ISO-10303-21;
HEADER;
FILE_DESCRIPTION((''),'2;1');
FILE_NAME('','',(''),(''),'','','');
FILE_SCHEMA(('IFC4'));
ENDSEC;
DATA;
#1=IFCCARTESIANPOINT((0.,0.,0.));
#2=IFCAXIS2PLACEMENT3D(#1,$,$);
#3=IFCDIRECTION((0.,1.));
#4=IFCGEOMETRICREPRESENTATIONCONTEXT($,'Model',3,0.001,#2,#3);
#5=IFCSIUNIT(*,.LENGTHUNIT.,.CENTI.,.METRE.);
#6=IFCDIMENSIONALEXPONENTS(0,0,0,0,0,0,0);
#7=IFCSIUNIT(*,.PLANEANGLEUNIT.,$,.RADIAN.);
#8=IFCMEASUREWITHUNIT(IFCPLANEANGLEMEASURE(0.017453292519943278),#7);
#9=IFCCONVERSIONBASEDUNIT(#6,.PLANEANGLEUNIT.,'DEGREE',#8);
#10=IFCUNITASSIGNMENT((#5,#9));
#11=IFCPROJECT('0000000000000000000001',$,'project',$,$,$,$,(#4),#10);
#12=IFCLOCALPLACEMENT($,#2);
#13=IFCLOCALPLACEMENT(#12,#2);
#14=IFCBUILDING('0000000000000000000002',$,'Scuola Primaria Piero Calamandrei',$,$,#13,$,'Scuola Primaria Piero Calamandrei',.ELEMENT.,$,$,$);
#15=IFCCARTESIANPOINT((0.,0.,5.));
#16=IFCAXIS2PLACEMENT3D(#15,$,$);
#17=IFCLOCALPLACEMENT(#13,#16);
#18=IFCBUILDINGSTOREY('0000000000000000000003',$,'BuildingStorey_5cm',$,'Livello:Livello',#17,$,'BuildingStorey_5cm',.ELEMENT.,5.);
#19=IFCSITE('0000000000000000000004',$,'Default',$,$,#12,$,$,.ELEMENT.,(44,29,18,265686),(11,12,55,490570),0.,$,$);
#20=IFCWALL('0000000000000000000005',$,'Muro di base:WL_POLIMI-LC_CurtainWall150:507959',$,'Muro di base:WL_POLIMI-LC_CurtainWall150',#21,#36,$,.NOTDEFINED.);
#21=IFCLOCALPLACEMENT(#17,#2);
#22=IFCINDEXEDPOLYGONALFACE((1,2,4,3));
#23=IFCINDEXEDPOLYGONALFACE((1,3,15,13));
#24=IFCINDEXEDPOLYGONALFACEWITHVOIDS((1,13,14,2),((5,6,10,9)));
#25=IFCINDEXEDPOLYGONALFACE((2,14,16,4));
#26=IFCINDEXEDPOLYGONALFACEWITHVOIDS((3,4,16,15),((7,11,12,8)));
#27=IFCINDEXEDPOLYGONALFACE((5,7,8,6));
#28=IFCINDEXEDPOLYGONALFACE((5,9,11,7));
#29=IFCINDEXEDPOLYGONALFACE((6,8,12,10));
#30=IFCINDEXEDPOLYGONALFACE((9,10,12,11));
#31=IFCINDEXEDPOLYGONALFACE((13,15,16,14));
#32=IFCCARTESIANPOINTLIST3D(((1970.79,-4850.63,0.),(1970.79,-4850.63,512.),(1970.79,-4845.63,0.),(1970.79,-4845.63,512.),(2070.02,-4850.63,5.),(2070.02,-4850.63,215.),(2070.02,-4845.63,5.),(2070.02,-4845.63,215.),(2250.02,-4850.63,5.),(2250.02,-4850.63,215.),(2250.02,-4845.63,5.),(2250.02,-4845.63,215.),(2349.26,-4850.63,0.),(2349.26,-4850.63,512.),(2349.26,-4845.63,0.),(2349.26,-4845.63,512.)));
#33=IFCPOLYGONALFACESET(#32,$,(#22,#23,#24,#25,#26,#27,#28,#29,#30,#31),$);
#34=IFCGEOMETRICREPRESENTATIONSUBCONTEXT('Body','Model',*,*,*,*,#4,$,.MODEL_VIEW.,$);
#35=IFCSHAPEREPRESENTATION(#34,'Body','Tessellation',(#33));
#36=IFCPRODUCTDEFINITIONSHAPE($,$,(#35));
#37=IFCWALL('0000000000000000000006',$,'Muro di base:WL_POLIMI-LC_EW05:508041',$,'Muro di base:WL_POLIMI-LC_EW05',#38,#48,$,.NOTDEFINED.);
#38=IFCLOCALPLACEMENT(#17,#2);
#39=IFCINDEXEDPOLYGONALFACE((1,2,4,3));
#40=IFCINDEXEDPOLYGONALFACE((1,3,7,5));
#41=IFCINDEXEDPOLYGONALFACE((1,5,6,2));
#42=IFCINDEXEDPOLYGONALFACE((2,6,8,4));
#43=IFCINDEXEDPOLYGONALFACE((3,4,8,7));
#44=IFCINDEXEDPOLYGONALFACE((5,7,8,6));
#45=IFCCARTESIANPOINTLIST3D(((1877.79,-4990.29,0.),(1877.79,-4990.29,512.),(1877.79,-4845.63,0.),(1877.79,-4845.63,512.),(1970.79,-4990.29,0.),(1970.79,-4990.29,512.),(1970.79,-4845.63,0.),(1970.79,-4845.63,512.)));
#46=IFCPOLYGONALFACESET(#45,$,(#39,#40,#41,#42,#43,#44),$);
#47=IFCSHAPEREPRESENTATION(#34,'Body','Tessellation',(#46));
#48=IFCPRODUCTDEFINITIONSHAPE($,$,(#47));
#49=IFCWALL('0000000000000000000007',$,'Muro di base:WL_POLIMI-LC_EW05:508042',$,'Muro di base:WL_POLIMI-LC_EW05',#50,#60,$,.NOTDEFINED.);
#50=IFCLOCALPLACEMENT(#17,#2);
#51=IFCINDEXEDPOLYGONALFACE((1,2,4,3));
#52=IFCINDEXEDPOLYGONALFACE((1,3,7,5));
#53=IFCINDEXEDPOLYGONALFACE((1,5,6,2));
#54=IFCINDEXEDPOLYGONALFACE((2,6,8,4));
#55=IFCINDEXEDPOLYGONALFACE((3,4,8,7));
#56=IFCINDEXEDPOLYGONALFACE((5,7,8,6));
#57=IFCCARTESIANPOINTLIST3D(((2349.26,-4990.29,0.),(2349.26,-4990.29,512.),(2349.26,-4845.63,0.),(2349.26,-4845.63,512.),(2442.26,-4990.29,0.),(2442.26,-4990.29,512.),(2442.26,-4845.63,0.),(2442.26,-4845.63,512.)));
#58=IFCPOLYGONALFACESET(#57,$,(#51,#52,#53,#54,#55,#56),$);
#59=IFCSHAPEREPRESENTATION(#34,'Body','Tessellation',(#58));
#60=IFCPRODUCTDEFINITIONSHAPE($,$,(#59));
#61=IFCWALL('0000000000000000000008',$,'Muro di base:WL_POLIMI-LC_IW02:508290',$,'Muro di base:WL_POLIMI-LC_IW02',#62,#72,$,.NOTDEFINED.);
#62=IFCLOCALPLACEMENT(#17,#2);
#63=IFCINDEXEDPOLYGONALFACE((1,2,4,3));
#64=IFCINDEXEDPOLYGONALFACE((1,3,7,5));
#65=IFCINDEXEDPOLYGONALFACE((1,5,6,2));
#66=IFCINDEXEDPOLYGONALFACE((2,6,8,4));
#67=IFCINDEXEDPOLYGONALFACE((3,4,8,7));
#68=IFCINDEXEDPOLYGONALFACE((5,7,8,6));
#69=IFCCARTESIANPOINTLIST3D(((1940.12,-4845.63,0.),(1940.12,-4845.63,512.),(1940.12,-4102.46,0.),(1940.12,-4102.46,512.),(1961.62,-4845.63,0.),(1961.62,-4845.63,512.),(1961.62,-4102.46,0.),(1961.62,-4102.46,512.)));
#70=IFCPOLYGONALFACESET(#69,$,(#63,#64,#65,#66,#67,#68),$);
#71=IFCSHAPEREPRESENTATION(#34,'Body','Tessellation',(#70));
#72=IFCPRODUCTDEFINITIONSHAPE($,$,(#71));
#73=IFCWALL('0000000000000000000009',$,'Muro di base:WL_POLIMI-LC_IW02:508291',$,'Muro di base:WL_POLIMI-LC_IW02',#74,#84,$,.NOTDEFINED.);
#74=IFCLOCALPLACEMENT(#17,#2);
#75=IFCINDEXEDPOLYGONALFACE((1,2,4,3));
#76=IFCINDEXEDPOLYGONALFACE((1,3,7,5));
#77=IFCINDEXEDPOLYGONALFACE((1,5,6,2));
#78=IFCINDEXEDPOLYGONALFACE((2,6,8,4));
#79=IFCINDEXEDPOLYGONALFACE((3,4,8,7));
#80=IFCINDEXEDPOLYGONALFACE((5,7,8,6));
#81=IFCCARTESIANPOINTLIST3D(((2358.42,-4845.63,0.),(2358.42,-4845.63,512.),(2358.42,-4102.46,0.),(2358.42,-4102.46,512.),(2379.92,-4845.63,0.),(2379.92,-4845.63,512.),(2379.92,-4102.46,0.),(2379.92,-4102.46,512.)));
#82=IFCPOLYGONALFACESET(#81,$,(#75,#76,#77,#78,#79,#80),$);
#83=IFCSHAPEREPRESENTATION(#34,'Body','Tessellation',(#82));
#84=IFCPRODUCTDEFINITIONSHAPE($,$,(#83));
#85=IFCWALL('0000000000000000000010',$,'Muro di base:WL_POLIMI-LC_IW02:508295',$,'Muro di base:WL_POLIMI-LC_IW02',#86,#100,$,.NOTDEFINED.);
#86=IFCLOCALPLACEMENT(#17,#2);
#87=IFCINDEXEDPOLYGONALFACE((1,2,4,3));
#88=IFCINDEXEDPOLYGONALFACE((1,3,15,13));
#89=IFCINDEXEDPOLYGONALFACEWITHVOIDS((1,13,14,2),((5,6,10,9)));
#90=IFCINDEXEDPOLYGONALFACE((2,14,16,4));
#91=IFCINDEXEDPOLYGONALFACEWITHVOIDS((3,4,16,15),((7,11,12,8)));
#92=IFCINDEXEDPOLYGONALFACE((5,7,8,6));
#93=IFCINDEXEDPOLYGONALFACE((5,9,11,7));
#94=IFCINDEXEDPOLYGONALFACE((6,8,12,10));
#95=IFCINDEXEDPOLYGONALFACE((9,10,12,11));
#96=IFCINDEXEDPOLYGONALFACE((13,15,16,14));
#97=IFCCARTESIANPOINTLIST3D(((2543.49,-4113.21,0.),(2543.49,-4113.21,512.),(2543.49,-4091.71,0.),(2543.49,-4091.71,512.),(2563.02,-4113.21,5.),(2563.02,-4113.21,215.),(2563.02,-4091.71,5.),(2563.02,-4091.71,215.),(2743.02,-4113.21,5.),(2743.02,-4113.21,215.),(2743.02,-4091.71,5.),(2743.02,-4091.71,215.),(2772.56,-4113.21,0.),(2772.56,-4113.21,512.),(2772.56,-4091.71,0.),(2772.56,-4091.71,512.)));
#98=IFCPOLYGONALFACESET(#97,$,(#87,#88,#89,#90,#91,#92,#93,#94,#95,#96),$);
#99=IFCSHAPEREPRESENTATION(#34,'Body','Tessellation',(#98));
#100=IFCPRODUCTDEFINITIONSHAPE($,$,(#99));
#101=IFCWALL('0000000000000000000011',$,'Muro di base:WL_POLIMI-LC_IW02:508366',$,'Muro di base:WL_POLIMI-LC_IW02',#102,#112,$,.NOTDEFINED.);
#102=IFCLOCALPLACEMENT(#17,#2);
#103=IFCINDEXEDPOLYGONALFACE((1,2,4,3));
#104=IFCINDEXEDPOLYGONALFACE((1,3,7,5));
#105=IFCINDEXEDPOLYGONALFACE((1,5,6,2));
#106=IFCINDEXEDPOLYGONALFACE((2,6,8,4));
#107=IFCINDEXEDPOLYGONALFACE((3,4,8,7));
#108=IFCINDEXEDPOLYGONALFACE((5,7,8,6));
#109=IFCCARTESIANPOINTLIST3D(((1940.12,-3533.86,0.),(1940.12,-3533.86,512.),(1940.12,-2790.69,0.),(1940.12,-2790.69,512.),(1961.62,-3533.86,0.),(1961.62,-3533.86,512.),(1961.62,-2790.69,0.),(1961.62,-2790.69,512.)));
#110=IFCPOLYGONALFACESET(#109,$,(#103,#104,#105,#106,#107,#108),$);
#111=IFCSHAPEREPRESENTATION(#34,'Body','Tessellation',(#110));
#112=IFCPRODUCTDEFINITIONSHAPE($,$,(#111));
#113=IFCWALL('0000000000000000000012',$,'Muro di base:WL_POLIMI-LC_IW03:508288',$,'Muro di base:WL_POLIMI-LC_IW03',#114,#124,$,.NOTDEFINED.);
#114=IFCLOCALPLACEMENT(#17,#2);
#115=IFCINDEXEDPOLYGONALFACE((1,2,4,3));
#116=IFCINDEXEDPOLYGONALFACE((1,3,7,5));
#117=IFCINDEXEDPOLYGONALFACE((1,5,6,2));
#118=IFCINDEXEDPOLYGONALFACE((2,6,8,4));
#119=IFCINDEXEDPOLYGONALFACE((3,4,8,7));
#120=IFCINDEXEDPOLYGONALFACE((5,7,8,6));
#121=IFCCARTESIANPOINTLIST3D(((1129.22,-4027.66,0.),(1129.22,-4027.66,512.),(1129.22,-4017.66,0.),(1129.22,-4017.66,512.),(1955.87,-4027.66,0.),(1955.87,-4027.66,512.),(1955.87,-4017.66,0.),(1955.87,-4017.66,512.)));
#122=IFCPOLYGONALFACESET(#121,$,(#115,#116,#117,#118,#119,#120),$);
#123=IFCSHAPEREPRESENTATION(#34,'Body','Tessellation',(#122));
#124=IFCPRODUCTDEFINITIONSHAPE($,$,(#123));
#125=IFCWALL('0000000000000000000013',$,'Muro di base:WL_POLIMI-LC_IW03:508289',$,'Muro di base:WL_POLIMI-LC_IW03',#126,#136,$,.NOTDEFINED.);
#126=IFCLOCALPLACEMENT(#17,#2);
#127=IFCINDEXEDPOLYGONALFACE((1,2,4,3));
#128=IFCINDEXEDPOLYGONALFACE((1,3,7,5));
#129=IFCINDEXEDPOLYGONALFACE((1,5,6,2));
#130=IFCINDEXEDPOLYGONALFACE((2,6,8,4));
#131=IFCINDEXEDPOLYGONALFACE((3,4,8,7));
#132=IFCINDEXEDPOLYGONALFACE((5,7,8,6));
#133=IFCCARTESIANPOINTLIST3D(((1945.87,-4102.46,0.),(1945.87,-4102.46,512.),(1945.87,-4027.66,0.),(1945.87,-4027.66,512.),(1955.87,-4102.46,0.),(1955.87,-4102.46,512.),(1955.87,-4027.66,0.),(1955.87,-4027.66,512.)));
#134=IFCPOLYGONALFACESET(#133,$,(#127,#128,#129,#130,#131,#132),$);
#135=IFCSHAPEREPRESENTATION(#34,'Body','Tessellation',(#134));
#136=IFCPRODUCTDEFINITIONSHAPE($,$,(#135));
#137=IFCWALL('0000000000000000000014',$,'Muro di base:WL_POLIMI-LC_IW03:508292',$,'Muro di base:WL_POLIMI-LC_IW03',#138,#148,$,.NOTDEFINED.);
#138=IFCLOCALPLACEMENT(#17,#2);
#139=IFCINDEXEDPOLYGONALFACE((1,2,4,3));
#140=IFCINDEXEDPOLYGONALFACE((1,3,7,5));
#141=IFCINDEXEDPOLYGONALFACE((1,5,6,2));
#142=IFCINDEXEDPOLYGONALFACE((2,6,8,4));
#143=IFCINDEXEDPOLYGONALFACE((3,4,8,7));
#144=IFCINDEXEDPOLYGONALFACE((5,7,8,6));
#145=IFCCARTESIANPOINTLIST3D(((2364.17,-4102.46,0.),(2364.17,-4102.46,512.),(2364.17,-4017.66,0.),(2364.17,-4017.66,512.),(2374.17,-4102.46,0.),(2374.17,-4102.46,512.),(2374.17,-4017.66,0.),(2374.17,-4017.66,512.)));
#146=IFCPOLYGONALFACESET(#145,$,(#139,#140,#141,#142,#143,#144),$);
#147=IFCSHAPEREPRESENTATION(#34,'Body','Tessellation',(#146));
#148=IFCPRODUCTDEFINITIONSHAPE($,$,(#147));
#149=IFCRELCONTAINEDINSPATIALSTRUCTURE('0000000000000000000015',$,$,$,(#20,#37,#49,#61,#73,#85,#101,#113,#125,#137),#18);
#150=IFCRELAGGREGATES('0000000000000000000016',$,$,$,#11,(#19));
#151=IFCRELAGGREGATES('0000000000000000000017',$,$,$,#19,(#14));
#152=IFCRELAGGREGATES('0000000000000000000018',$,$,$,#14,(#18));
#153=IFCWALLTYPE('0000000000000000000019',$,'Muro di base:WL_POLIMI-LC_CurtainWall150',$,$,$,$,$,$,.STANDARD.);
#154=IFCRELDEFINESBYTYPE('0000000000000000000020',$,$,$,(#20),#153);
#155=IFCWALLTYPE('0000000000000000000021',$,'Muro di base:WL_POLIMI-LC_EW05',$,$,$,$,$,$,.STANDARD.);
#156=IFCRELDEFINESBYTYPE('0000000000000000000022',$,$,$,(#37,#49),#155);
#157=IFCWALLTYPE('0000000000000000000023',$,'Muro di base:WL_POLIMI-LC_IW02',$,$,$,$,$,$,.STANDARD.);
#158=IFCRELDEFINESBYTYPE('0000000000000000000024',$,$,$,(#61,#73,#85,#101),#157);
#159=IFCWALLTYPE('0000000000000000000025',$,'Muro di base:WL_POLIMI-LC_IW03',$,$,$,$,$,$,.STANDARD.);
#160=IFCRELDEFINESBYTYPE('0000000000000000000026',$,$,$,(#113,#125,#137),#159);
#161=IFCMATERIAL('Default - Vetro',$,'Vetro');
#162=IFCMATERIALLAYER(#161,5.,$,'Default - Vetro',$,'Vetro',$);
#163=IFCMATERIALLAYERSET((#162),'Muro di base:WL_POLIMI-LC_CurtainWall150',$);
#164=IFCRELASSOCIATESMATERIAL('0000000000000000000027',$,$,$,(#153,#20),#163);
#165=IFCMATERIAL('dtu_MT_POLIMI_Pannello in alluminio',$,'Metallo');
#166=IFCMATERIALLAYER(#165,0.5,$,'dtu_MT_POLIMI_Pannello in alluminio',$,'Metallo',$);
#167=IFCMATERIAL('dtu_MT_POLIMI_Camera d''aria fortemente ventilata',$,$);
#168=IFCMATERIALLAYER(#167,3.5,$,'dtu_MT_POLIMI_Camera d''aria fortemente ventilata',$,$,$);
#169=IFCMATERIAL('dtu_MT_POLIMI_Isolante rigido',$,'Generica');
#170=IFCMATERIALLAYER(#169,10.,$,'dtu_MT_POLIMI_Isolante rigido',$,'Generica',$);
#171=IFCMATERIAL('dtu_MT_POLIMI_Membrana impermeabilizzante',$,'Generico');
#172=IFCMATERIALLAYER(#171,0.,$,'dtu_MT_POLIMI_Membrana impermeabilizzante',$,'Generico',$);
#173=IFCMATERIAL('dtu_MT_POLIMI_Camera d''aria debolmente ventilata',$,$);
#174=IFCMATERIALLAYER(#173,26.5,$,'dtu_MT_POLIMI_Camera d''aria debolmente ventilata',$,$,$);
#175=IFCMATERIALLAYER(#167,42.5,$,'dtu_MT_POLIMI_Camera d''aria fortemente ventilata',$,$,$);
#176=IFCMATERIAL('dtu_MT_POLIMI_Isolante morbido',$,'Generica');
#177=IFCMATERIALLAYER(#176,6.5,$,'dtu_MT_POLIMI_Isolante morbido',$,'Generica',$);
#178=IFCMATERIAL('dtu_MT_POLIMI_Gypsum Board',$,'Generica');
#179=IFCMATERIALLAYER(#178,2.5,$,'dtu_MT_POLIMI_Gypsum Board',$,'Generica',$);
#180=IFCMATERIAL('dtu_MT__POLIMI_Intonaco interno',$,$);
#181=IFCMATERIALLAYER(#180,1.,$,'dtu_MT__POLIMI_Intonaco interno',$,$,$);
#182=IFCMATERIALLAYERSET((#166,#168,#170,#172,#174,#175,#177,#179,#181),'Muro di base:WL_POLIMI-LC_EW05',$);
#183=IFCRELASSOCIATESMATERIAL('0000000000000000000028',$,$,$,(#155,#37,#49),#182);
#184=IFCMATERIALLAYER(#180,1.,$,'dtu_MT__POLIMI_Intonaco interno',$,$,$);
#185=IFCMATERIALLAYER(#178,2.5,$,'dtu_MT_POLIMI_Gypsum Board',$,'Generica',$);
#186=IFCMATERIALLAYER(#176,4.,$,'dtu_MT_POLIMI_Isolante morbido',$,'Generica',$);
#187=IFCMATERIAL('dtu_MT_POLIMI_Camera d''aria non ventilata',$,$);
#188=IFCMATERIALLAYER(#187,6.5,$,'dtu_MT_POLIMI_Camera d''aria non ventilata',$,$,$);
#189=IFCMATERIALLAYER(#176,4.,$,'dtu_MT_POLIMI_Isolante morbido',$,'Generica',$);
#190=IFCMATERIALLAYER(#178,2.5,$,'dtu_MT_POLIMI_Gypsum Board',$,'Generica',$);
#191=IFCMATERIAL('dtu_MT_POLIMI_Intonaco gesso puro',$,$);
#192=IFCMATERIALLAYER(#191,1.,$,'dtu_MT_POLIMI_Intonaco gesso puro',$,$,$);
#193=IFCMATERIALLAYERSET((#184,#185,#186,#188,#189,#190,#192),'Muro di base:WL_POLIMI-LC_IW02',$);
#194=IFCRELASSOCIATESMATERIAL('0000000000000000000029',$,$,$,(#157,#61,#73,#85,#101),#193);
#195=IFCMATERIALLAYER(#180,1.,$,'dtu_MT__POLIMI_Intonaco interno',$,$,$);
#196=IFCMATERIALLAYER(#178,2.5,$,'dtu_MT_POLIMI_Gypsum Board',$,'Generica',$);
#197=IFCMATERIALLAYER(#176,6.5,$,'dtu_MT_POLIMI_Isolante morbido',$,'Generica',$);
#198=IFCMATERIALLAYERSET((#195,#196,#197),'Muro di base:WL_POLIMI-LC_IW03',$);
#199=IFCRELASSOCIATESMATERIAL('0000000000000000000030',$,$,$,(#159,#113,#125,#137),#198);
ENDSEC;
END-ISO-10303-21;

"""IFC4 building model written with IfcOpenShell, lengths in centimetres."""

from ifc_helpers import new_model, entity, si_unit, converted_unit, direction, frame, frame_2d, origin, origin_2d_with_axis, place, context, subcontext, project, spatial, rectangle, extrude, material, layer, layer_set, layer_usage, type_object, element, save


model = new_model("IFC4")

# Units and contexts
model_context = context("Model", 3, precision=0.001, world=origin(), true_north=direction((0.0, 1.0)))
body_context = subcontext(model_context, "Body", "Model", "MODEL_VIEW")
ifc_project = project(units=[si_unit("LENGTHUNIT", "METRE", prefix="CENTI"), converted_unit("PLANEANGLEUNIT", "DEGREE", entity("IfcPlaneAngleMeasure", 0.017453292519943278), si_unit("PLANEANGLEUNIT", "RADIAN"), dimensions=[0, 0, 0, 0, 0, 0, 0])], contexts=[model_context])

# Site, building, storey
site_placement = place(None, origin())
site = spatial("IfcSite", under=ifc_project, at=site_placement, Name="Default", CompositionType="ELEMENT", RefLatitude=(44, 29, 18, 265686), RefLongitude=(11, 12, 55, 490570), RefElevation=0.0)
building_placement = place(site_placement, origin())
building = spatial("IfcBuilding", under=site, at=building_placement, Name="Scuola Primaria Piero Calamandrei", LongName="Scuola Primaria Piero Calamandrei", CompositionType="ELEMENT")
storey_placement = place(building_placement, frame((0.0, 0.0, 5.0)))
storey = spatial("IfcBuildingStorey", under=building, at=storey_placement, Name="BuildingStorey_5cm", ObjectType="Livello:Livello", LongName="BuildingStorey_5cm", CompositionType="ELEMENT", Elevation=5.0)

# Wall, openings
ifc_material_1 = material(Name="Default - Vetro", Category="Vetro")
ifc_layer_1 = layer(ifc_material_1, 5.0, Name="Default - Vetro", Category="Vetro")
ifc_layer_set_1 = layer_set([ifc_layer_1], Name="Muro di base:WL_POLIMI-LC_CurtainWall150")
ifc_layer_usage_1 = layer_usage(ifc_layer_set_1, "AXIS2", "NEGATIVE", 2.5)
wall_type_1 = type_object("IfcWallType", Name="Muro di base:WL_POLIMI-LC_CurtainWall150", PredefinedType="STANDARD", material=ifc_layer_set_1)
wall_1_placement = place(storey_placement, frame((2349.26, -4848.13, 0.0), z_axis=(0.0, 0.0, 1.0), x_axis=(-1.0, 0.0, 0.0)))
wall_1 = element("IfcWall", 1, at=wall_1_placement, inside=storey, type_object=wall_type_1, material=ifc_layer_usage_1, Name="Muro di base:WL_POLIMI-LC_CurtainWall150:507959", ObjectType="Muro di base:WL_POLIMI-LC_CurtainWall150", PredefinedType="NOTDEFINED", context=body_context, shape_type="SweptSolid", body=[
    extrude(rectangle(XDim=5.0, YDim=378.47, at=frame_2d((0.0, 0.0), x_axis=(1.0, 0.0))), frame((189.23, 0.0, 0.0), z_axis=(0.0, 0.0, 1.0), x_axis=(0.0, 1.0, 0.0)), (0.0, 0.0, 1.0), 512.0),
])
opening_1_placement = place(storey_placement, frame((2349.26, -4848.13, 0.0), z_axis=(0.0, 0.0, 1.0), x_axis=(-1.0, 0.0, 0.0)))
element("IfcOpeningElement", 2, at=opening_1_placement, cuts=wall_1, PredefinedType="OPENING", context=body_context, shape_type="SweptSolid", body=[
    extrude(rectangle(XDim=210.0, YDim=180.0, at=origin_2d_with_axis()), frame((189.23, 2.5, 110.0), z_axis=(0.0, -1.0, 0.0), x_axis=(0.0, 0.0, -1.0)), (0.0, 0.0, 1.0), 5.0),
])
opening_2_placement = place(wall_1_placement, frame((99.23, -2.5, 5.0)))
element("IfcOpeningElement", 3, at=opening_2_placement, cuts=wall_1, PredefinedType="OPENING", context=body_context, shape_type="SweptSolid", body=[
    extrude(rectangle(XDim=210.0, YDim=180.0, at=frame_2d((105.0, 90.0), x_axis=(-1.0, 0.0))), frame((0.0, 0.0, 0.0), z_axis=(0.0, 1.0, 0.0), x_axis=(0.0, 0.0, 1.0)), (0.0, 0.0, 1.0), 5.0),
])

# Walls
ifc_material_2 = material(Name="dtu_MT_POLIMI_Pannello in alluminio", Category="Metallo")
ifc_layer_2 = layer(ifc_material_2, 0.5, Name="dtu_MT_POLIMI_Pannello in alluminio", Category="Metallo")
ifc_material_3 = material(Name="dtu_MT_POLIMI_Camera d'aria fortemente ventilata")
ifc_layer_3 = layer(ifc_material_3, 3.5, Name="dtu_MT_POLIMI_Camera d'aria fortemente ventilata")
ifc_material_4 = material(Name="dtu_MT_POLIMI_Isolante rigido", Category="Generica")
ifc_layer_4 = layer(ifc_material_4, 10.0, Name="dtu_MT_POLIMI_Isolante rigido", Category="Generica")
ifc_material_5 = material(Name="dtu_MT_POLIMI_Membrana impermeabilizzante", Category="Generico")
ifc_layer_5 = layer(ifc_material_5, 0.0, Name="dtu_MT_POLIMI_Membrana impermeabilizzante", Category="Generico")
ifc_material_6 = material(Name="dtu_MT_POLIMI_Camera d'aria debolmente ventilata")
ifc_layer_6 = layer(ifc_material_6, 26.5, Name="dtu_MT_POLIMI_Camera d'aria debolmente ventilata")
ifc_layer_7 = layer(ifc_material_3, 42.5, Name="dtu_MT_POLIMI_Camera d'aria fortemente ventilata")
ifc_material_7 = material(Name="dtu_MT_POLIMI_Isolante morbido", Category="Generica")
ifc_layer_8 = layer(ifc_material_7, 6.5, Name="dtu_MT_POLIMI_Isolante morbido", Category="Generica")
ifc_material_8 = material(Name="dtu_MT_POLIMI_Gypsum Board", Category="Generica")
ifc_layer_9 = layer(ifc_material_8, 2.5, Name="dtu_MT_POLIMI_Gypsum Board", Category="Generica")
ifc_material_9 = material(Name="dtu_MT__POLIMI_Intonaco interno")
ifc_layer_10 = layer(ifc_material_9, 1.0, Name="dtu_MT__POLIMI_Intonaco interno")
ifc_layer_set_2 = layer_set([ifc_layer_2, ifc_layer_3, ifc_layer_4, ifc_layer_5, ifc_layer_6, ifc_layer_7, ifc_layer_8, ifc_layer_9, ifc_layer_10], Name="Muro di base:WL_POLIMI-LC_EW05")
ifc_layer_usage_2 = layer_usage(ifc_layer_set_2, "AXIS2", "NEGATIVE", 46.5)
wall_type_2 = type_object("IfcWallType", Name="Muro di base:WL_POLIMI-LC_EW05", PredefinedType="STANDARD", material=ifc_layer_set_2)
wall_2_placement = place(storey_placement, frame((1924.29, -4845.63, 0.0), z_axis=(0.0, 0.0, 1.0), x_axis=(0.0, -1.0, 0.0)))
element("IfcWall", 4, at=wall_2_placement, inside=storey, type_object=wall_type_2, material=ifc_layer_usage_2, Name="Muro di base:WL_POLIMI-LC_EW05:508041", ObjectType="Muro di base:WL_POLIMI-LC_EW05", PredefinedType="NOTDEFINED", context=body_context, shape_type="SweptSolid", body=[
    extrude(rectangle(XDim=144.66, YDim=93.0, at=frame_2d((72.33, 0.0), x_axis=(-1.0, 0.0))), origin(), (0.0, 0.0, 1.0), 512.0),
])
ifc_layer_usage_3 = layer_usage(ifc_layer_set_2, "AXIS2", "NEGATIVE", 46.5)
wall_3_placement = place(storey_placement, frame((2395.76, -4990.29, 0.0), z_axis=(0.0, 0.0, 1.0), x_axis=(0.0, 1.0, 0.0)))
element("IfcWall", 5, at=wall_3_placement, inside=storey, type_object=wall_type_2, material=ifc_layer_usage_3, Name="Muro di base:WL_POLIMI-LC_EW05:508042", ObjectType="Muro di base:WL_POLIMI-LC_EW05", PredefinedType="NOTDEFINED", context=body_context, shape_type="SweptSolid", body=[
    extrude(rectangle(XDim=144.66, YDim=93.0, at=frame_2d((72.33, 0.0), x_axis=(-1.0, 0.0))), origin(), (0.0, 0.0, 1.0), 512.0),
])
ifc_layer_11 = layer(ifc_material_9, 1.0, Name="dtu_MT__POLIMI_Intonaco interno")
ifc_layer_12 = layer(ifc_material_8, 2.5, Name="dtu_MT_POLIMI_Gypsum Board", Category="Generica")
ifc_layer_13 = layer(ifc_material_7, 4.0, Name="dtu_MT_POLIMI_Isolante morbido", Category="Generica")
ifc_material_10 = material(Name="dtu_MT_POLIMI_Camera d'aria non ventilata")
ifc_layer_14 = layer(ifc_material_10, 6.5, Name="dtu_MT_POLIMI_Camera d'aria non ventilata")
ifc_layer_15 = layer(ifc_material_7, 4.0, Name="dtu_MT_POLIMI_Isolante morbido", Category="Generica")
ifc_layer_16 = layer(ifc_material_8, 2.5, Name="dtu_MT_POLIMI_Gypsum Board", Category="Generica")
ifc_material_11 = material(Name="dtu_MT_POLIMI_Intonaco gesso puro")
ifc_layer_17 = layer(ifc_material_11, 1.0, Name="dtu_MT_POLIMI_Intonaco gesso puro")
ifc_layer_set_3 = layer_set([ifc_layer_11, ifc_layer_12, ifc_layer_13, ifc_layer_14, ifc_layer_15, ifc_layer_16, ifc_layer_17], Name="Muro di base:WL_POLIMI-LC_IW02")
ifc_layer_usage_4 = layer_usage(ifc_layer_set_3, "AXIS2", "NEGATIVE", 10.75)
wall_type_3 = type_object("IfcWallType", Name="Muro di base:WL_POLIMI-LC_IW02", PredefinedType="STANDARD", material=ifc_layer_set_3)
wall_4_placement = place(storey_placement, frame((1950.87, -4845.63, 0.0), z_axis=(0.0, 0.0, 1.0), x_axis=(0.0, 1.0, 0.0)))
element("IfcWall", 6, at=wall_4_placement, inside=storey, type_object=wall_type_3, material=ifc_layer_usage_4, Name="Muro di base:WL_POLIMI-LC_IW02:508290", ObjectType="Muro di base:WL_POLIMI-LC_IW02", PredefinedType="NOTDEFINED", context=body_context, shape_type="SweptSolid", body=[
    extrude(rectangle(XDim=743.17, YDim=21.5, at=frame_2d((371.58, 0.0), x_axis=(-1.0, 0.0))), origin(), (0.0, 0.0, 1.0), 512.0),
])
ifc_layer_usage_5 = layer_usage(ifc_layer_set_3, "AXIS2", "NEGATIVE", 10.75)
wall_5_placement = place(storey_placement, frame((2369.17, -4102.46, 0.0), z_axis=(0.0, 0.0, 1.0), x_axis=(0.0, -1.0, 0.0)))
element("IfcWall", 7, at=wall_5_placement, inside=storey, type_object=wall_type_3, material=ifc_layer_usage_5, Name="Muro di base:WL_POLIMI-LC_IW02:508291", ObjectType="Muro di base:WL_POLIMI-LC_IW02", PredefinedType="NOTDEFINED", context=body_context, shape_type="SweptSolid", body=[
    extrude(rectangle(XDim=743.17, YDim=21.5, at=frame_2d((371.58, 0.0), x_axis=(-1.0, 0.0))), origin(), (0.0, 0.0, 1.0), 512.0),
])

# Wall, opening
ifc_layer_usage_6 = layer_usage(ifc_layer_set_3, "AXIS2", "NEGATIVE", 10.75)
wall_6_placement = place(storey_placement, frame((2772.56, -4102.46, 0.0), z_axis=(0.0, 0.0, 1.0), x_axis=(-1.0, 0.0, 0.0)))
wall_6 = element("IfcWall", 8, at=wall_6_placement, inside=storey, type_object=wall_type_3, material=ifc_layer_usage_6, Name="Muro di base:WL_POLIMI-LC_IW02:508295", ObjectType="Muro di base:WL_POLIMI-LC_IW02", PredefinedType="NOTDEFINED", context=body_context, shape_type="SweptSolid", body=[
    extrude(rectangle(XDim=229.07, YDim=21.5, at=frame_2d((114.54, 0.0), x_axis=(-1.0, 0.0))), origin(), (0.0, 0.0, 1.0), 512.0),
])
opening_3_placement = place(wall_6_placement, frame((209.54, 10.75, 5.0)))
element("IfcOpeningElement", 9, at=opening_3_placement, cuts=wall_6, PredefinedType="OPENING", context=body_context, shape_type="SweptSolid", body=[
    extrude(rectangle(XDim=210.0, YDim=180.0, at=frame_2d((105.0, 90.0), x_axis=(-1.0, 0.0))), frame((0.0, 0.0, 0.0), z_axis=(0.0, -1.0, 0.0), x_axis=(0.0, 0.0, 1.0)), (0.0, 0.0, 1.0), 21.5),
])

# Walls
ifc_layer_usage_7 = layer_usage(ifc_layer_set_3, "AXIS2", "NEGATIVE", 10.75)
wall_7_placement = place(storey_placement, frame((1950.87, -3533.86, 0.0), z_axis=(0.0, 0.0, 1.0), x_axis=(0.0, 1.0, 0.0)))
element("IfcWall", 10, at=wall_7_placement, inside=storey, type_object=wall_type_3, material=ifc_layer_usage_7, Name="Muro di base:WL_POLIMI-LC_IW02:508366", ObjectType="Muro di base:WL_POLIMI-LC_IW02", PredefinedType="NOTDEFINED", context=body_context, shape_type="SweptSolid", body=[
    extrude(rectangle(XDim=743.17, YDim=21.5, at=frame_2d((371.58, 0.0), x_axis=(-1.0, 0.0))), origin(), (0.0, 0.0, 1.0), 512.0),
])
ifc_layer_18 = layer(ifc_material_9, 1.0, Name="dtu_MT__POLIMI_Intonaco interno")
ifc_layer_19 = layer(ifc_material_8, 2.5, Name="dtu_MT_POLIMI_Gypsum Board", Category="Generica")
ifc_layer_20 = layer(ifc_material_7, 6.5, Name="dtu_MT_POLIMI_Isolante morbido", Category="Generica")
ifc_layer_set_4 = layer_set([ifc_layer_18, ifc_layer_19, ifc_layer_20], Name="Muro di base:WL_POLIMI-LC_IW03")
ifc_layer_usage_8 = layer_usage(ifc_layer_set_4, "AXIS2", "NEGATIVE", 5.0)
wall_type_4 = type_object("IfcWallType", Name="Muro di base:WL_POLIMI-LC_IW03", PredefinedType="STANDARD", material=ifc_layer_set_4)
wall_8_placement = place(storey_placement, frame((1955.87, -4022.66, 0.0), z_axis=(0.0, 0.0, 1.0), x_axis=(-1.0, 0.0, 0.0)))
element("IfcWall", 11, at=wall_8_placement, inside=storey, type_object=wall_type_4, material=ifc_layer_usage_8, Name="Muro di base:WL_POLIMI-LC_IW03:508288", ObjectType="Muro di base:WL_POLIMI-LC_IW03", PredefinedType="NOTDEFINED", context=body_context, shape_type="SweptSolid", body=[
    extrude(rectangle(XDim=826.65, YDim=10.0, at=frame_2d((413.32, 0.0), x_axis=(-1.0, 0.0))), origin(), (0.0, 0.0, 1.0), 512.0),
])
ifc_layer_usage_9 = layer_usage(ifc_layer_set_4, "AXIS2", "NEGATIVE", 5.0)
wall_9_placement = place(storey_placement, frame((1950.87, -4102.46, 0.0), z_axis=(0.0, 0.0, 1.0), x_axis=(0.0, 1.0, 0.0)))
element("IfcWall", 12, at=wall_9_placement, inside=storey, type_object=wall_type_4, material=ifc_layer_usage_9, Name="Muro di base:WL_POLIMI-LC_IW03:508289", ObjectType="Muro di base:WL_POLIMI-LC_IW03", PredefinedType="NOTDEFINED", context=body_context, shape_type="SweptSolid", body=[
    extrude(rectangle(XDim=74.8, YDim=10.0, at=frame_2d((37.4, 0.0), x_axis=(-1.0, 0.0))), origin(), (0.0, 0.0, 1.0), 512.0),
])
ifc_layer_usage_10 = layer_usage(ifc_layer_set_4, "AXIS2", "NEGATIVE", 5.0)
wall_10_placement = place(storey_placement, frame((2369.17, -4017.66, 0.0), z_axis=(0.0, 0.0, 1.0), x_axis=(0.0, -1.0, 0.0)))
element("IfcWall", 13, at=wall_10_placement, inside=storey, type_object=wall_type_4, material=ifc_layer_usage_10, Name="Muro di base:WL_POLIMI-LC_IW03:508292", ObjectType="Muro di base:WL_POLIMI-LC_IW03", PredefinedType="NOTDEFINED", context=body_context, shape_type="SweptSolid", body=[
    extrude(rectangle(XDim=84.8, YDim=10.0, at=frame_2d((42.4, 0.0), x_axis=(-1.0, 0.0))), origin(), (0.0, 0.0, 1.0), 512.0),
])

save(model, "model.ifc")
